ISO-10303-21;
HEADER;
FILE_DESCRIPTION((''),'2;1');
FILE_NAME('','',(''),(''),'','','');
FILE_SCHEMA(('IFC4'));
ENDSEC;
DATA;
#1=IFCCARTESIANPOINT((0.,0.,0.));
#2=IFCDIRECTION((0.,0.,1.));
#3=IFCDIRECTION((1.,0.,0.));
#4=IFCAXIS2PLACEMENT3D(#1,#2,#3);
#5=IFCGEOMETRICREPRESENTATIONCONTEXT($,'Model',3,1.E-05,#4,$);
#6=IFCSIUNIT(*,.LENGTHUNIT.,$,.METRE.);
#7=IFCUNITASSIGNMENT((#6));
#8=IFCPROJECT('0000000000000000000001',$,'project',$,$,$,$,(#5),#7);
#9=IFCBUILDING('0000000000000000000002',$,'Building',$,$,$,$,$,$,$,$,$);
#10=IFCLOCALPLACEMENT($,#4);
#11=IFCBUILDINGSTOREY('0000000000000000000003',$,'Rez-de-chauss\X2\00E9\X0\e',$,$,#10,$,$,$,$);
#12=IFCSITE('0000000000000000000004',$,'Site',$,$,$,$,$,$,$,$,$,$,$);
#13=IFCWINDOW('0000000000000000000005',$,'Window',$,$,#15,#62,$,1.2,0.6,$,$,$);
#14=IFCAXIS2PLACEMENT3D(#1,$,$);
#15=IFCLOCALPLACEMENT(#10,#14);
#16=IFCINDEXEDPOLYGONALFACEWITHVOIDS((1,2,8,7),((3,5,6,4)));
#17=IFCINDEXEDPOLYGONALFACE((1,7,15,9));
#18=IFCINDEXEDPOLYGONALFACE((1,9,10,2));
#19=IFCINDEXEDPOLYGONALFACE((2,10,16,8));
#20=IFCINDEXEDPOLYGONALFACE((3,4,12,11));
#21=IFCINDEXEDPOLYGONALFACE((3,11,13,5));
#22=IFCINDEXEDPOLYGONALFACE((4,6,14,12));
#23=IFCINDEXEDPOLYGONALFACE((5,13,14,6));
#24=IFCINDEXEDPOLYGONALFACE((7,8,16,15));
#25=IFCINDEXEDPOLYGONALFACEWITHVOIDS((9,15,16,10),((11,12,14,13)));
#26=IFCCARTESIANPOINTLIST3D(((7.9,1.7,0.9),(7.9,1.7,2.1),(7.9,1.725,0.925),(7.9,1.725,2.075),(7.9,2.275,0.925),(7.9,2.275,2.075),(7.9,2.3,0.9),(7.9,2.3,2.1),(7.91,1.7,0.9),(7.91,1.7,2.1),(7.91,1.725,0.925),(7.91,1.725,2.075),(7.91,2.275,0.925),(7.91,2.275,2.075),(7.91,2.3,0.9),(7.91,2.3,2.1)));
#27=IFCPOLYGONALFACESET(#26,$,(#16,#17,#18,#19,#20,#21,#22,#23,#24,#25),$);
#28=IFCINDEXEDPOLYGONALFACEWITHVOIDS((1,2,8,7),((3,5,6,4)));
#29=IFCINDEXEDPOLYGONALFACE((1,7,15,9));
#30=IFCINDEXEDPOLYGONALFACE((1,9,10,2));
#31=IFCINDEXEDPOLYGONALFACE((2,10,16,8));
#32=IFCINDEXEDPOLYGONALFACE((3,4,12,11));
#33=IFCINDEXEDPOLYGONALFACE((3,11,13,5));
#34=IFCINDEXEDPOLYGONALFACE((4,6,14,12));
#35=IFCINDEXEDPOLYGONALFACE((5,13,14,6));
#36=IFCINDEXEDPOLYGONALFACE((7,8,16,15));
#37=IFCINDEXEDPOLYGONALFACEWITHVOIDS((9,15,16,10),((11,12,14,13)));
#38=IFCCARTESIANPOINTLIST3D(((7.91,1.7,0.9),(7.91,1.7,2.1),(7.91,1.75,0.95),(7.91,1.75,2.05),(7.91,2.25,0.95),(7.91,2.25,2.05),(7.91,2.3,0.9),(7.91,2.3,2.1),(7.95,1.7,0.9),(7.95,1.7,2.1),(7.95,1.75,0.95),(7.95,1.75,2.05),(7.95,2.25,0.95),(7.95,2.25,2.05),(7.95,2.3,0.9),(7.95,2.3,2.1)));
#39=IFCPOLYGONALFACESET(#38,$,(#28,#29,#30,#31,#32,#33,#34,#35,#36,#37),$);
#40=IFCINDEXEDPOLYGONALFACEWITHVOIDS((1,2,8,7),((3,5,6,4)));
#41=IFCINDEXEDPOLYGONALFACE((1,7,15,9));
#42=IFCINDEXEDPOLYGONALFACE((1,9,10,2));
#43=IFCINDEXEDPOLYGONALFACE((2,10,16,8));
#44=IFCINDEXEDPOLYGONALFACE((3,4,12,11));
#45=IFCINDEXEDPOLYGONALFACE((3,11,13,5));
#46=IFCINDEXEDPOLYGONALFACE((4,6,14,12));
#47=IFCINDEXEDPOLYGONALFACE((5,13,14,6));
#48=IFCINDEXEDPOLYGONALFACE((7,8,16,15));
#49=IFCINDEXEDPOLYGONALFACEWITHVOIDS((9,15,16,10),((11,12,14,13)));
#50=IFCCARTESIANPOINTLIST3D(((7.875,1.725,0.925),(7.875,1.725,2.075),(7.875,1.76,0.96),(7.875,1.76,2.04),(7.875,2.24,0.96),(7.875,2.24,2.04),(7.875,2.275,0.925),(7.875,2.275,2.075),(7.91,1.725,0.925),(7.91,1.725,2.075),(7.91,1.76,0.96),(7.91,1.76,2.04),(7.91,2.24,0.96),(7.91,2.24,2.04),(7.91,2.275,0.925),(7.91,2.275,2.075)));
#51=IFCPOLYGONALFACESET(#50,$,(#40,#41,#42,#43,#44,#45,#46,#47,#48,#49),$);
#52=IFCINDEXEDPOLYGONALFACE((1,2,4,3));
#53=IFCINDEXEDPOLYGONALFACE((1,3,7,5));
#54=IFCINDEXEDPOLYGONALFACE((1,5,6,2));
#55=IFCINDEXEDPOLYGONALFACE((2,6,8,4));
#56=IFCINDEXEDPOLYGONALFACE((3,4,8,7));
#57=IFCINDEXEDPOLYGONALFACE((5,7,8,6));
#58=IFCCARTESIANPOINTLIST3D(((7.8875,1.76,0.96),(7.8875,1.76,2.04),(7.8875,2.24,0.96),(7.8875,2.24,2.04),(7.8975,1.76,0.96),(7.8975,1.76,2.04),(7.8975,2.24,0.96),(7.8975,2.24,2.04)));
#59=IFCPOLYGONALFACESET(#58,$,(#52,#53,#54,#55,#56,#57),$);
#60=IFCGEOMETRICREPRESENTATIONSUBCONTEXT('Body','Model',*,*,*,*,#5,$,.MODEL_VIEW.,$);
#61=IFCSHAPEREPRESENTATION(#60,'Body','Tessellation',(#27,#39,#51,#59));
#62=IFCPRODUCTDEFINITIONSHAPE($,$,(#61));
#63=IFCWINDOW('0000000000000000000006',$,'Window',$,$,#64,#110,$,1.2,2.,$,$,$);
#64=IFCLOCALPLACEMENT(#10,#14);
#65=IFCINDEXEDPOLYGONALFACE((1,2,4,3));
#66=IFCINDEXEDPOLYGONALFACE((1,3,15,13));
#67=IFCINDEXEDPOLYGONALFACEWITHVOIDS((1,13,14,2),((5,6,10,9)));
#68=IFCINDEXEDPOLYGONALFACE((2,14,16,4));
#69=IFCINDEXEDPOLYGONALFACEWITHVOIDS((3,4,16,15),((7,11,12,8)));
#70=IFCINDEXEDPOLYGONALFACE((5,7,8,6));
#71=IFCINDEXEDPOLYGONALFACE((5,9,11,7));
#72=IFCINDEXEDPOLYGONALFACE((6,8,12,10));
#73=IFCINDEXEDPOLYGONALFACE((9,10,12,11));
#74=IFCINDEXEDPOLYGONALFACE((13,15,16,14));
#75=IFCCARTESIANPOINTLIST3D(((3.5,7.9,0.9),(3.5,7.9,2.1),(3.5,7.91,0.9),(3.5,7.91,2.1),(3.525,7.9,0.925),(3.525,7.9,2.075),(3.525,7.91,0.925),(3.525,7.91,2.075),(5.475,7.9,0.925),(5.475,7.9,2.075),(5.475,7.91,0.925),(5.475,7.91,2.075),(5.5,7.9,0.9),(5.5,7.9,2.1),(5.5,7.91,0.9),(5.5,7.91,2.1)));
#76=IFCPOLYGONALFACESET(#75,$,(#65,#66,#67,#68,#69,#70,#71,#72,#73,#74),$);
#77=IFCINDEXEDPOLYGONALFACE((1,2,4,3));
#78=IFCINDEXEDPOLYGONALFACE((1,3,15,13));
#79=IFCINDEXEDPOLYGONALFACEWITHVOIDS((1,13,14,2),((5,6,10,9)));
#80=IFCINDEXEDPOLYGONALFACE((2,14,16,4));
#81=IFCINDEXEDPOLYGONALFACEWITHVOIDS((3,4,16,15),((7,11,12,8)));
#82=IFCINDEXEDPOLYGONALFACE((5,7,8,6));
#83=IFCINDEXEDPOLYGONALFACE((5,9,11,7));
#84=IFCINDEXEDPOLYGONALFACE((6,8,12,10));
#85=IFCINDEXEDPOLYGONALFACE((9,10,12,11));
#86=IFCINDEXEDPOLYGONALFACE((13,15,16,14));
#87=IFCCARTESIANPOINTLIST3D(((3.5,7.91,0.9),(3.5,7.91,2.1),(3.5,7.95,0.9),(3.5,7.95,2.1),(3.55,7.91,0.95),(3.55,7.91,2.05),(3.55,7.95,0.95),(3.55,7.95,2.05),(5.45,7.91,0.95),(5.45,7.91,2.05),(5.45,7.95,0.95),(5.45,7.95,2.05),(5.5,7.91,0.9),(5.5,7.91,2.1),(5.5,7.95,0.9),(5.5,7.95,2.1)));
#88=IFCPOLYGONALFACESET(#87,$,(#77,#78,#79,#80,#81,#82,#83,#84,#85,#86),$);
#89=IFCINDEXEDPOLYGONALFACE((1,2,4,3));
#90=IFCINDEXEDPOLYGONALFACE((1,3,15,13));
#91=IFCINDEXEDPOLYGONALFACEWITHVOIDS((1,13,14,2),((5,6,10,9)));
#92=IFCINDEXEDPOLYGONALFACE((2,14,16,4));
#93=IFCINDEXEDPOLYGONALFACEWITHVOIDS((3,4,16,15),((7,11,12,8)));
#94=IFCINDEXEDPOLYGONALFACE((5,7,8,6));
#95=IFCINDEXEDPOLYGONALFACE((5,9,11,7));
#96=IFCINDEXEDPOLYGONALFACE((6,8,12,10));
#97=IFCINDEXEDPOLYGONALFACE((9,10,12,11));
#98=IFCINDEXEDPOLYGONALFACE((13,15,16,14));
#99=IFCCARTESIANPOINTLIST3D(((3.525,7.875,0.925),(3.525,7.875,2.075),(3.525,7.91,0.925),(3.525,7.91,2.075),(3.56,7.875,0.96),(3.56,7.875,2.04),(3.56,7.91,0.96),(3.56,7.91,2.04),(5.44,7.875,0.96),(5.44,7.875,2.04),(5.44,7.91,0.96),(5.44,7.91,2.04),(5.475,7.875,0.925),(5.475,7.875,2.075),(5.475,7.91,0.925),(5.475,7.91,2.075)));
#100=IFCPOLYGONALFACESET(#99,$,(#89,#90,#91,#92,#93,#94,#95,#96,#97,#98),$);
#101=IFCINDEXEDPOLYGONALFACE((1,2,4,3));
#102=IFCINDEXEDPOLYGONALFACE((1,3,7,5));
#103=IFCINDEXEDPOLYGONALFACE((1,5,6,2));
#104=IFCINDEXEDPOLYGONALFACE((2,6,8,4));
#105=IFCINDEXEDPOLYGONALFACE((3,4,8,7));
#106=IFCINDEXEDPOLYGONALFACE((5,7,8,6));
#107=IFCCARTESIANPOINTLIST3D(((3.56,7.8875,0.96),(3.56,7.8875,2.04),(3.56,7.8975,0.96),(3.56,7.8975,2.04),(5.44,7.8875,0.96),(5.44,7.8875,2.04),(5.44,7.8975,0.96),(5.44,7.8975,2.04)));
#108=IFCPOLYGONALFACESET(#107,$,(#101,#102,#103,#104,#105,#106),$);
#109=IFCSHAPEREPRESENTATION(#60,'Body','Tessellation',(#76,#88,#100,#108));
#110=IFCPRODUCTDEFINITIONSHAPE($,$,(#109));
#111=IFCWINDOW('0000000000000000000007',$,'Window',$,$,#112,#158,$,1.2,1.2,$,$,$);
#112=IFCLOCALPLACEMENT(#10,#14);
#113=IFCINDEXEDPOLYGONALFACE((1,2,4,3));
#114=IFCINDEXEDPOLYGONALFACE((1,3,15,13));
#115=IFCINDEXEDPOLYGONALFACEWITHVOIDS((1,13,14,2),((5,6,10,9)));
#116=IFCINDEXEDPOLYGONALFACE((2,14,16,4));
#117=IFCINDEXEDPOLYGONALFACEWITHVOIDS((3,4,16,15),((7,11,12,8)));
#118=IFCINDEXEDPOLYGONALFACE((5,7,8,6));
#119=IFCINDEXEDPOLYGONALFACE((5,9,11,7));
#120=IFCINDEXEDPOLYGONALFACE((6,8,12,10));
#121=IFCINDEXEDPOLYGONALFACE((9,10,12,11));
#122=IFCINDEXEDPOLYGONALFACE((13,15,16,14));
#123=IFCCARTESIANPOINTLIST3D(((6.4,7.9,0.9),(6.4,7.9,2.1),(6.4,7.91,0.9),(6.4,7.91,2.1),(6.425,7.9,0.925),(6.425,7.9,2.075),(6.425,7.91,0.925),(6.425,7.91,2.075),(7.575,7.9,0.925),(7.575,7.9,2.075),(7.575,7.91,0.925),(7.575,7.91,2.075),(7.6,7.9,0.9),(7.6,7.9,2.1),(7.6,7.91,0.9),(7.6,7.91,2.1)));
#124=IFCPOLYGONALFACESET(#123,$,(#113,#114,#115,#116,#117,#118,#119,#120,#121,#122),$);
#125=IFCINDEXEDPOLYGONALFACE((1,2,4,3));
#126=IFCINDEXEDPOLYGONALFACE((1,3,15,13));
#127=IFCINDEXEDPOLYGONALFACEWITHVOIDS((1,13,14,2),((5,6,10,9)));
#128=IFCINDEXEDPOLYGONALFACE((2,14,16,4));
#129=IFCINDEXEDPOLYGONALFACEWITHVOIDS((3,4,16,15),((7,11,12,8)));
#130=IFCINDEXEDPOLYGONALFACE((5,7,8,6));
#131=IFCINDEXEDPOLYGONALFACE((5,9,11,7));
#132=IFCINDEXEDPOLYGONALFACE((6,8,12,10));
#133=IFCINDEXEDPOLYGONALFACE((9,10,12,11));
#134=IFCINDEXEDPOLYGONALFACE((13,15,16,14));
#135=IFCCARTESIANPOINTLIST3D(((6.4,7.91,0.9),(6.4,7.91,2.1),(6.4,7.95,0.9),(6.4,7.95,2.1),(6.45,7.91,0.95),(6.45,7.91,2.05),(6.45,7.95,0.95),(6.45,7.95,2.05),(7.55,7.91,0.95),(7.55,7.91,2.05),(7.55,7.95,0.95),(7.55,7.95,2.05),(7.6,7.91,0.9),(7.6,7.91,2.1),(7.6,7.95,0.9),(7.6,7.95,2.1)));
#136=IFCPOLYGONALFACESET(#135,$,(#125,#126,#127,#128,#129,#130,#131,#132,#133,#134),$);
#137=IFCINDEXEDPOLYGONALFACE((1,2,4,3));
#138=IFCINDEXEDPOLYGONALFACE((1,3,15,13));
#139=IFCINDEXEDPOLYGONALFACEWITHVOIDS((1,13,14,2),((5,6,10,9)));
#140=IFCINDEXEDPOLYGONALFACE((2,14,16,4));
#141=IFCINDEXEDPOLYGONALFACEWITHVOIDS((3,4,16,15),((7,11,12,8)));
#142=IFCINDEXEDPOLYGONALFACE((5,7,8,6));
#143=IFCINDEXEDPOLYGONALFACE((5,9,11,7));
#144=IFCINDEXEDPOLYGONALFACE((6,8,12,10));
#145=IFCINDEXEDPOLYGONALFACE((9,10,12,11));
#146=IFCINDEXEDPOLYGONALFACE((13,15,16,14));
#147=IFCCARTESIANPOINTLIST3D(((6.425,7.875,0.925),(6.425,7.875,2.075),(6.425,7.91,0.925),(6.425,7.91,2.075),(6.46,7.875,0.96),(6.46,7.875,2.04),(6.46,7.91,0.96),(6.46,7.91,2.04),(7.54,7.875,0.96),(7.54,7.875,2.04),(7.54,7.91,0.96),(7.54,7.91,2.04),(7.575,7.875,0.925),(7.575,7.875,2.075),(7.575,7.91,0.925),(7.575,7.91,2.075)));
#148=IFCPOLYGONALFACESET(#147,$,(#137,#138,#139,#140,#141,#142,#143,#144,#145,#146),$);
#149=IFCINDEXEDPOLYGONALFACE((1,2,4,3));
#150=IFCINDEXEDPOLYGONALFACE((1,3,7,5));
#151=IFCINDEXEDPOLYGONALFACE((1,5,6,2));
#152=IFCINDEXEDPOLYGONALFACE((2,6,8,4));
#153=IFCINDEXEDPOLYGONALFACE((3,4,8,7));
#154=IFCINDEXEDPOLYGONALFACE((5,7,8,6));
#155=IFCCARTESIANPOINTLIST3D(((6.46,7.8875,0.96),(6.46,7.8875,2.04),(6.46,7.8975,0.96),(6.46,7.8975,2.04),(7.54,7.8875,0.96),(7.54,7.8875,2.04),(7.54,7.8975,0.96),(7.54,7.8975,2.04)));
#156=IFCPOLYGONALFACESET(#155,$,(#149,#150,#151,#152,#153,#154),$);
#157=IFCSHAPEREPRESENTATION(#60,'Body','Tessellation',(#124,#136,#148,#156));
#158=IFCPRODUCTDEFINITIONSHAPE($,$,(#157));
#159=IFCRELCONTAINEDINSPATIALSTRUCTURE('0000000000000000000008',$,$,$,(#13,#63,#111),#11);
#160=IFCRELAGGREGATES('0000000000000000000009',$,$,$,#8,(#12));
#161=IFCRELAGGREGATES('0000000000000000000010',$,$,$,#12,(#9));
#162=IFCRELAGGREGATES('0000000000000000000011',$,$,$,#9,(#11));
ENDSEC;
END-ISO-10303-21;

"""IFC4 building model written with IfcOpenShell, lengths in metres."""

from ifc_helpers import new_model, si_unit, frame, origin_with_axes, place, context, subcontext, project, spatial, line, indexed_curve, outline, extrude, element, save


model = new_model("IFC4")

# Units and contexts
model_context = context("Model", 3, precision=1e-05, world=origin_with_axes())
body_context = subcontext(model_context, "Body", "Model", "MODEL_VIEW")
ifc_project = project(units=[si_unit("LENGTHUNIT", "METRE")], contexts=[model_context])

# Site, building, storey
site = spatial("IfcSite", under=ifc_project, Name="Site")
building = spatial("IfcBuilding", under=site, Name="Building")
storey_placement = place(None, origin_with_axes())
storey = spatial("IfcBuildingStorey", under=building, at=storey_placement, Name="Rez-de-chaussée")

# Windows
window_1_placement = place(storey_placement, frame((8.0, 1.7, 0.9), z_axis=(0.0, 0.0, 1.0), x_axis=(0.0, 1.0, 0.0)))
element("IfcWindow", 1, at=window_1_placement, inside=storey, Name="Window", OverallHeight=1.2, OverallWidth=0.6, context=body_context, shape_type="SweptSolid", body=[
    extrude(outline(indexed_curve([(0.0, 0.0), (0.6, 0.0), (0.6, 1.2), (0.0, 1.2)], segments=[line(1, 2, 3, 4, 1)]), holes=[indexed_curve([(0.025, 0.025), (0.575, 0.025), (0.575, 1.175), (0.025, 1.175)], segments=[line(1, 2, 3, 4, 1)])]), frame((0.0, 0.09, 0.0), z_axis=(0.0, -1.0, 0.0), x_axis=(1.0, 0.0, 0.0)), (0.0, 0.0, -1.0), 0.01),
    extrude(outline(indexed_curve([(0.0, 0.0), (0.6, 0.0), (0.6, 1.2), (0.0, 1.2)], segments=[line(1, 2, 3, 4, 1)]), holes=[indexed_curve([(0.05, 0.05), (0.55, 0.05), (0.55, 1.15), (0.05, 1.15)], segments=[line(1, 2, 3, 4, 1)])]), frame((0.0, 0.05, 0.0), z_axis=(0.0, -1.0, 0.0), x_axis=(1.0, 0.0, 0.0)), (0.0, 0.0, -1.0), 0.04),
    extrude(outline(indexed_curve([(0.0, 0.0), (0.55, 0.0), (0.55, 1.15), (0.0, 1.15)], segments=[line(1, 2, 3, 4, 1)]), holes=[indexed_curve([(0.035, 0.035), (0.515, 0.035), (0.515, 1.115), (0.035, 1.115)], segments=[line(1, 2, 3, 4, 1)])]), frame((0.025, 0.09, 0.025), z_axis=(0.0, -1.0, 0.0), x_axis=(1.0, 0.0, 0.0)), (0.0, 0.0, -1.0), 0.035),
    extrude(outline(indexed_curve([(0.035, 0.035), (0.515, 0.035), (0.515, 1.115), (0.035, 1.115)], segments=[line(1, 2, 3, 4, 1)])), frame((0.025, 0.1025, 0.025), z_axis=(0.0, -1.0, 0.0), x_axis=(1.0, 0.0, 0.0)), (0.0, 0.0, -1.0), 0.01),
])
window_2_placement = place(storey_placement, frame((5.5, 8.0, 0.9), z_axis=(0.0, 0.0, 1.0), x_axis=(-1.0, 0.0, 0.0)))
element("IfcWindow", 2, at=window_2_placement, inside=storey, Name="Window", OverallHeight=1.2, OverallWidth=2.0, context=body_context, shape_type="SweptSolid", body=[
    extrude(outline(indexed_curve([(0.0, 0.0), (2.0, 0.0), (2.0, 1.2), (0.0, 1.2)], segments=[line(1, 2, 3, 4, 1)]), holes=[indexed_curve([(0.025, 0.025), (1.975, 0.025), (1.975, 1.175), (0.025, 1.175)], segments=[line(1, 2, 3, 4, 1)])]), frame((0.0, 0.09, 0.0), z_axis=(0.0, -1.0, 0.0), x_axis=(1.0, 0.0, 0.0)), (0.0, 0.0, -1.0), 0.01),
    extrude(outline(indexed_curve([(0.0, 0.0), (2.0, 0.0), (2.0, 1.2), (0.0, 1.2)], segments=[line(1, 2, 3, 4, 1)]), holes=[indexed_curve([(0.05, 0.05), (1.95, 0.05), (1.95, 1.15), (0.05, 1.15)], segments=[line(1, 2, 3, 4, 1)])]), frame((0.0, 0.05, 0.0), z_axis=(0.0, -1.0, 0.0), x_axis=(1.0, 0.0, 0.0)), (0.0, 0.0, -1.0), 0.04),
    extrude(outline(indexed_curve([(0.0, 0.0), (1.95, 0.0), (1.95, 1.15), (0.0, 1.15)], segments=[line(1, 2, 3, 4, 1)]), holes=[indexed_curve([(0.035, 0.035), (1.915, 0.035), (1.915, 1.115), (0.035, 1.115)], segments=[line(1, 2, 3, 4, 1)])]), frame((0.025, 0.09, 0.025), z_axis=(0.0, -1.0, 0.0), x_axis=(1.0, 0.0, 0.0)), (0.0, 0.0, -1.0), 0.035),
    extrude(outline(indexed_curve([(0.035, 0.035), (1.915, 0.035), (1.915, 1.115), (0.035, 1.115)], segments=[line(1, 2, 3, 4, 1)])), frame((0.025, 0.1025, 0.025), z_axis=(0.0, -1.0, 0.0), x_axis=(1.0, 0.0, 0.0)), (0.0, 0.0, -1.0), 0.01),
])
window_3_placement = place(storey_placement, frame((7.6, 8.0, 0.9), z_axis=(0.0, 0.0, 1.0), x_axis=(-1.0, 0.0, 0.0)))
element("IfcWindow", 3, at=window_3_placement, inside=storey, Name="Window", OverallHeight=1.2, OverallWidth=1.2, context=body_context, shape_type="SweptSolid", body=[
    extrude(outline(indexed_curve([(0.0, 0.0), (1.2, 0.0), (1.2, 1.2), (0.0, 1.2)], segments=[line(1, 2, 3, 4, 1)]), holes=[indexed_curve([(0.025, 0.025), (1.175, 0.025), (1.175, 1.175), (0.025, 1.175)], segments=[line(1, 2, 3, 4, 1)])]), frame((0.0, 0.09, 0.0), z_axis=(0.0, -1.0, 0.0), x_axis=(1.0, 0.0, 0.0)), (0.0, 0.0, -1.0), 0.01),
    extrude(outline(indexed_curve([(0.0, 0.0), (1.2, 0.0), (1.2, 1.2), (0.0, 1.2)], segments=[line(1, 2, 3, 4, 1)]), holes=[indexed_curve([(0.05, 0.05), (1.15, 0.05), (1.15, 1.15), (0.05, 1.15)], segments=[line(1, 2, 3, 4, 1)])]), frame((0.0, 0.05, 0.0), z_axis=(0.0, -1.0, 0.0), x_axis=(1.0, 0.0, 0.0)), (0.0, 0.0, -1.0), 0.04),
    extrude(outline(indexed_curve([(0.0, 0.0), (1.15, 0.0), (1.15, 1.15), (0.0, 1.15)], segments=[line(1, 2, 3, 4, 1)]), holes=[indexed_curve([(0.035, 0.035), (1.115, 0.035), (1.115, 1.115), (0.035, 1.115)], segments=[line(1, 2, 3, 4, 1)])]), frame((0.025, 0.09, 0.025), z_axis=(0.0, -1.0, 0.0), x_axis=(1.0, 0.0, 0.0)), (0.0, 0.0, -1.0), 0.035),
    extrude(outline(indexed_curve([(0.035, 0.035), (1.115, 0.035), (1.115, 1.115), (0.035, 1.115)], segments=[line(1, 2, 3, 4, 1)])), frame((0.025, 0.1025, 0.025), z_axis=(0.0, -1.0, 0.0), x_axis=(1.0, 0.0, 0.0)), (0.0, 0.0, -1.0), 0.01),
])

save(model, "model.ifc")
